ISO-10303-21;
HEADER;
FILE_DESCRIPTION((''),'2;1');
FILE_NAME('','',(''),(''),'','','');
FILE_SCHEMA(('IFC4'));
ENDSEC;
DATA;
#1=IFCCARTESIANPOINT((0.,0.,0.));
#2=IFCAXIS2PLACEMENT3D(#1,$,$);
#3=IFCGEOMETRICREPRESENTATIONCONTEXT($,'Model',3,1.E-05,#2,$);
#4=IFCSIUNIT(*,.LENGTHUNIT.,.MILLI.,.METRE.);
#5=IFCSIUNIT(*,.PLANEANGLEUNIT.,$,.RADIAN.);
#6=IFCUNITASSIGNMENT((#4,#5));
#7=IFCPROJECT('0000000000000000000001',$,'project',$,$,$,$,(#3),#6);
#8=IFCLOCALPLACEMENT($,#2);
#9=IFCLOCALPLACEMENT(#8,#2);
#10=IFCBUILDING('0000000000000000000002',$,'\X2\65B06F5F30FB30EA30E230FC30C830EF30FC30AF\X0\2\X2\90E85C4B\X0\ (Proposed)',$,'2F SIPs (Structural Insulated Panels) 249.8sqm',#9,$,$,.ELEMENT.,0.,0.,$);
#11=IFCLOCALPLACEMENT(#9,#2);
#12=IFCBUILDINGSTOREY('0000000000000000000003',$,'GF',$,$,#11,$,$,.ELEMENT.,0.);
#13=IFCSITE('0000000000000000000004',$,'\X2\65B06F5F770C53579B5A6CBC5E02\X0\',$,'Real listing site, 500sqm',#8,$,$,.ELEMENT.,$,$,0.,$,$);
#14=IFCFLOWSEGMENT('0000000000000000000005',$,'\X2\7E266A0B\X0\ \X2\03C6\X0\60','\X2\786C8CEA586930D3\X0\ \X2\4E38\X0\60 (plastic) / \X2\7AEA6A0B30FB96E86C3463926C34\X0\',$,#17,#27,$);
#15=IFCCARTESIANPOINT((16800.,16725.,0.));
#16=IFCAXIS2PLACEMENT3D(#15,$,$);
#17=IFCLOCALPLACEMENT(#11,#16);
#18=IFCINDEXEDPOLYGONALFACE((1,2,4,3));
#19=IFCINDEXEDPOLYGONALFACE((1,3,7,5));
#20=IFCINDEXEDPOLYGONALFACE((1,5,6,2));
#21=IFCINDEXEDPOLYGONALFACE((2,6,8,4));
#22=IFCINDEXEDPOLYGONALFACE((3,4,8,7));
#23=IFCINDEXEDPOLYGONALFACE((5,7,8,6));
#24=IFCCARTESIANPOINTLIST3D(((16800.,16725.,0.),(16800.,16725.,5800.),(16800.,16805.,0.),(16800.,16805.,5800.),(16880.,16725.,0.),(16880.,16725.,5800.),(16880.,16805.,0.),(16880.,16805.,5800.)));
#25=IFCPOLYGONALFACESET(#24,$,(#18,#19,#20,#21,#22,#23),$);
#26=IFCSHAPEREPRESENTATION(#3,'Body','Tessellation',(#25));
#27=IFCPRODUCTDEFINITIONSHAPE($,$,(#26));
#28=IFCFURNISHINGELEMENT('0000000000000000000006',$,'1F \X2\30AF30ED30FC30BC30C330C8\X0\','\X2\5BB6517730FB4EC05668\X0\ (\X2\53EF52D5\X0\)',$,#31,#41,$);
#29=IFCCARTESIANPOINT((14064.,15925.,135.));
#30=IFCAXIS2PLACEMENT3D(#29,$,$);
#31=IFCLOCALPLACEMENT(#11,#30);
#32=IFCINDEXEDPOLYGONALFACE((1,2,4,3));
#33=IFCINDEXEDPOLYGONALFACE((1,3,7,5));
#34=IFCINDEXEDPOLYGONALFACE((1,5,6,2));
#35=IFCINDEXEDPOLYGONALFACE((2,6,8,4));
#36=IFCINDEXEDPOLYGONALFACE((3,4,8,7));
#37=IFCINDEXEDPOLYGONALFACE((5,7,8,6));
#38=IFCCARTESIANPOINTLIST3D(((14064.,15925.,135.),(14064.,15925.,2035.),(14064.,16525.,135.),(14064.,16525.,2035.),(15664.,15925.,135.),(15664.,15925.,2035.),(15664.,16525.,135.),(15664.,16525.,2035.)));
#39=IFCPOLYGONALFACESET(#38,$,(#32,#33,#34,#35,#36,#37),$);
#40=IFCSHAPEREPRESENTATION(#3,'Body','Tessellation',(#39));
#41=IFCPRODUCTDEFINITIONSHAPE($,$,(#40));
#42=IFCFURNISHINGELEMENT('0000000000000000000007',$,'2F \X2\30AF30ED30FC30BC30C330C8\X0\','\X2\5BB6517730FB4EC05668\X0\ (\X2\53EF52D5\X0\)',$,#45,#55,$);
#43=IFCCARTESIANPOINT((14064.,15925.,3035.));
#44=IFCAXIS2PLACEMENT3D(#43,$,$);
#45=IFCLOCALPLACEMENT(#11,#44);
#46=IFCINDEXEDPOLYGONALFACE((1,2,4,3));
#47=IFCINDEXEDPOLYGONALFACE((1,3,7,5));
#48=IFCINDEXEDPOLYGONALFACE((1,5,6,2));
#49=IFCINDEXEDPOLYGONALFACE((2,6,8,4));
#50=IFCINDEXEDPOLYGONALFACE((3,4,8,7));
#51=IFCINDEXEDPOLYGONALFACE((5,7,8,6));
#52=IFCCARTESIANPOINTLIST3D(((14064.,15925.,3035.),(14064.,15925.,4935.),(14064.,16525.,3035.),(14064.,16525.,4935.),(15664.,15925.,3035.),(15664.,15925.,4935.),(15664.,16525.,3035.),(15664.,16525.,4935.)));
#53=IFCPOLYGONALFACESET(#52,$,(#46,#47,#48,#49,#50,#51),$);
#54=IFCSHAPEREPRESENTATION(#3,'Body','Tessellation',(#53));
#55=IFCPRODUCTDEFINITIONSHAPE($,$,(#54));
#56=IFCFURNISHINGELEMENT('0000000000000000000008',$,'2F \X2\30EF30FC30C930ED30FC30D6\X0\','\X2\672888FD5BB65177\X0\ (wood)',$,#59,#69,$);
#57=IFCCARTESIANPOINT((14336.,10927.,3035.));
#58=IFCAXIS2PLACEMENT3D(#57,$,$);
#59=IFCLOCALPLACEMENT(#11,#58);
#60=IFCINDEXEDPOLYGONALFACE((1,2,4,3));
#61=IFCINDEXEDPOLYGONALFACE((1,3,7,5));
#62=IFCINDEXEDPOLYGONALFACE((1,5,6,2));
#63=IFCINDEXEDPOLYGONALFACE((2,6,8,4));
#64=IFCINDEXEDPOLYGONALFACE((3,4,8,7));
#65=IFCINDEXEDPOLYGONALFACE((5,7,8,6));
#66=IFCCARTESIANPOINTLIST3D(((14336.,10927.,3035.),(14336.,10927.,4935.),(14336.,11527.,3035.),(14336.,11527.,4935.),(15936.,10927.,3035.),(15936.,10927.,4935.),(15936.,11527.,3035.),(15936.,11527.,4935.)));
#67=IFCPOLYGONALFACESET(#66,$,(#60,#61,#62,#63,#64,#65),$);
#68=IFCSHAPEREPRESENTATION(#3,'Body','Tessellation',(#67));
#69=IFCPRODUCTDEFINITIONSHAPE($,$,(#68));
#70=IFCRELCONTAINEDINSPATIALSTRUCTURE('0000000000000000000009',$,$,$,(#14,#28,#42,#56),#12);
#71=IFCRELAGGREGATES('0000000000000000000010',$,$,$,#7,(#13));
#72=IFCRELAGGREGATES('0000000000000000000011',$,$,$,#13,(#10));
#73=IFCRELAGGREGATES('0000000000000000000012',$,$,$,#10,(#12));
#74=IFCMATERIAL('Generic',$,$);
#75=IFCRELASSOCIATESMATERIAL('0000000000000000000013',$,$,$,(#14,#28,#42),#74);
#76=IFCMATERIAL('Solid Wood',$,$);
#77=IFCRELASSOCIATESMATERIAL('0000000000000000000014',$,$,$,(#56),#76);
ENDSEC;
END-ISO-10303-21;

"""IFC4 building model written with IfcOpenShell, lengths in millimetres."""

from ifc_helpers import new_model, si_unit, frame, frame_2d, origin, place, context, project, spatial, rectangle, extrude, material, element, save


model = new_model("IFC4")

# Units and contexts
model_context = context("Model", 3, precision=1e-05, world=origin())
ifc_project = project(units=[si_unit("LENGTHUNIT", "METRE", prefix="MILLI"), si_unit("PLANEANGLEUNIT", "RADIAN")], contexts=[model_context])

# Site, building, storey
site_placement = place(None, origin())
site = spatial("IfcSite", under=ifc_project, at=site_placement, Name="新潟県南魚沼市", ObjectType="Real listing site, 500sqm", CompositionType="ELEMENT", RefElevation=0.0)
building_placement = place(site_placement, origin())
building = spatial("IfcBuilding", under=site, at=building_placement, Name="新潟・リモートワーク2部屋 (Proposed)", ObjectType="2F SIPs (Structural Insulated Panels) 249.8sqm", CompositionType="ELEMENT", ElevationOfRefHeight=0.0, ElevationOfTerrain=0.0)
storey_placement = place(building_placement, origin())
storey = spatial("IfcBuildingStorey", under=building, at=storey_placement, Name="GF", CompositionType="ELEMENT", Elevation=0.0)

# Shared definitions
ifc_material_1 = material(Name="Solid Wood")

# Shared definitions
ifc_material_2 = material(Name="Generic")

# Flow segment
flow_segment_placement = place(storey_placement, frame((16800.0, 16725.0, 0.0)))
element("IfcFlowSegment", 1, at=flow_segment_placement, inside=storey, material=ifc_material_2, Name="縦樋 φ60", Description="硬質塩ビ 丸60 (plastic) / 竪樋・雨水排水", context=model_context, shape_type="SweptSolid", body=[
    extrude(rectangle(XDim=80.0, YDim=80.0, at=frame_2d((40.0, 40.0))), frame((16800.0, 16725.0, 0.0)), (0.0, 0.0, 1.0), 5800.0),
])

# Furnishing elements
furnishing_1_placement = place(storey_placement, frame((14064.0, 15925.0, 135.0)))
element("IfcFurnishingElement", 2, at=furnishing_1_placement, inside=storey, material=ifc_material_2, Name="1F クローゼット", Description="家具・什器 (可動)", context=model_context, shape_type="SweptSolid", body=[
    extrude(rectangle(XDim=1600.0, YDim=600.0, at=frame_2d((800.0, 300.0))), frame((14064.0, 15925.0, 135.0)), (0.0, 0.0, 1.0), 1900.0),
])
furnishing_2_placement = place(storey_placement, frame((14064.0, 15925.0, 3035.0)))
element("IfcFurnishingElement", 3, at=furnishing_2_placement, inside=storey, material=ifc_material_2, Name="2F クローゼット", Description="家具・什器 (可動)", context=model_context, shape_type="SweptSolid", body=[
    extrude(rectangle(XDim=1600.0, YDim=600.0, at=frame_2d((800.0, 300.0))), frame((14064.0, 15925.0, 3035.0)), (0.0, 0.0, 1.0), 1900.0),
])
furnishing_3_placement = place(storey_placement, frame((14336.0, 10927.0, 3035.0)))
element("IfcFurnishingElement", 4, at=furnishing_3_placement, inside=storey, material=ifc_material_1, Name="2F ワードローブ", Description="木製家具 (wood)", context=model_context, shape_type="SweptSolid", body=[
    extrude(rectangle(XDim=1600.0, YDim=600.0, at=frame_2d((800.0, 300.0))), frame((14336.0, 10927.0, 3035.0)), (0.0, 0.0, 1.0), 1900.0),
])

save(model, "model.ifc")
